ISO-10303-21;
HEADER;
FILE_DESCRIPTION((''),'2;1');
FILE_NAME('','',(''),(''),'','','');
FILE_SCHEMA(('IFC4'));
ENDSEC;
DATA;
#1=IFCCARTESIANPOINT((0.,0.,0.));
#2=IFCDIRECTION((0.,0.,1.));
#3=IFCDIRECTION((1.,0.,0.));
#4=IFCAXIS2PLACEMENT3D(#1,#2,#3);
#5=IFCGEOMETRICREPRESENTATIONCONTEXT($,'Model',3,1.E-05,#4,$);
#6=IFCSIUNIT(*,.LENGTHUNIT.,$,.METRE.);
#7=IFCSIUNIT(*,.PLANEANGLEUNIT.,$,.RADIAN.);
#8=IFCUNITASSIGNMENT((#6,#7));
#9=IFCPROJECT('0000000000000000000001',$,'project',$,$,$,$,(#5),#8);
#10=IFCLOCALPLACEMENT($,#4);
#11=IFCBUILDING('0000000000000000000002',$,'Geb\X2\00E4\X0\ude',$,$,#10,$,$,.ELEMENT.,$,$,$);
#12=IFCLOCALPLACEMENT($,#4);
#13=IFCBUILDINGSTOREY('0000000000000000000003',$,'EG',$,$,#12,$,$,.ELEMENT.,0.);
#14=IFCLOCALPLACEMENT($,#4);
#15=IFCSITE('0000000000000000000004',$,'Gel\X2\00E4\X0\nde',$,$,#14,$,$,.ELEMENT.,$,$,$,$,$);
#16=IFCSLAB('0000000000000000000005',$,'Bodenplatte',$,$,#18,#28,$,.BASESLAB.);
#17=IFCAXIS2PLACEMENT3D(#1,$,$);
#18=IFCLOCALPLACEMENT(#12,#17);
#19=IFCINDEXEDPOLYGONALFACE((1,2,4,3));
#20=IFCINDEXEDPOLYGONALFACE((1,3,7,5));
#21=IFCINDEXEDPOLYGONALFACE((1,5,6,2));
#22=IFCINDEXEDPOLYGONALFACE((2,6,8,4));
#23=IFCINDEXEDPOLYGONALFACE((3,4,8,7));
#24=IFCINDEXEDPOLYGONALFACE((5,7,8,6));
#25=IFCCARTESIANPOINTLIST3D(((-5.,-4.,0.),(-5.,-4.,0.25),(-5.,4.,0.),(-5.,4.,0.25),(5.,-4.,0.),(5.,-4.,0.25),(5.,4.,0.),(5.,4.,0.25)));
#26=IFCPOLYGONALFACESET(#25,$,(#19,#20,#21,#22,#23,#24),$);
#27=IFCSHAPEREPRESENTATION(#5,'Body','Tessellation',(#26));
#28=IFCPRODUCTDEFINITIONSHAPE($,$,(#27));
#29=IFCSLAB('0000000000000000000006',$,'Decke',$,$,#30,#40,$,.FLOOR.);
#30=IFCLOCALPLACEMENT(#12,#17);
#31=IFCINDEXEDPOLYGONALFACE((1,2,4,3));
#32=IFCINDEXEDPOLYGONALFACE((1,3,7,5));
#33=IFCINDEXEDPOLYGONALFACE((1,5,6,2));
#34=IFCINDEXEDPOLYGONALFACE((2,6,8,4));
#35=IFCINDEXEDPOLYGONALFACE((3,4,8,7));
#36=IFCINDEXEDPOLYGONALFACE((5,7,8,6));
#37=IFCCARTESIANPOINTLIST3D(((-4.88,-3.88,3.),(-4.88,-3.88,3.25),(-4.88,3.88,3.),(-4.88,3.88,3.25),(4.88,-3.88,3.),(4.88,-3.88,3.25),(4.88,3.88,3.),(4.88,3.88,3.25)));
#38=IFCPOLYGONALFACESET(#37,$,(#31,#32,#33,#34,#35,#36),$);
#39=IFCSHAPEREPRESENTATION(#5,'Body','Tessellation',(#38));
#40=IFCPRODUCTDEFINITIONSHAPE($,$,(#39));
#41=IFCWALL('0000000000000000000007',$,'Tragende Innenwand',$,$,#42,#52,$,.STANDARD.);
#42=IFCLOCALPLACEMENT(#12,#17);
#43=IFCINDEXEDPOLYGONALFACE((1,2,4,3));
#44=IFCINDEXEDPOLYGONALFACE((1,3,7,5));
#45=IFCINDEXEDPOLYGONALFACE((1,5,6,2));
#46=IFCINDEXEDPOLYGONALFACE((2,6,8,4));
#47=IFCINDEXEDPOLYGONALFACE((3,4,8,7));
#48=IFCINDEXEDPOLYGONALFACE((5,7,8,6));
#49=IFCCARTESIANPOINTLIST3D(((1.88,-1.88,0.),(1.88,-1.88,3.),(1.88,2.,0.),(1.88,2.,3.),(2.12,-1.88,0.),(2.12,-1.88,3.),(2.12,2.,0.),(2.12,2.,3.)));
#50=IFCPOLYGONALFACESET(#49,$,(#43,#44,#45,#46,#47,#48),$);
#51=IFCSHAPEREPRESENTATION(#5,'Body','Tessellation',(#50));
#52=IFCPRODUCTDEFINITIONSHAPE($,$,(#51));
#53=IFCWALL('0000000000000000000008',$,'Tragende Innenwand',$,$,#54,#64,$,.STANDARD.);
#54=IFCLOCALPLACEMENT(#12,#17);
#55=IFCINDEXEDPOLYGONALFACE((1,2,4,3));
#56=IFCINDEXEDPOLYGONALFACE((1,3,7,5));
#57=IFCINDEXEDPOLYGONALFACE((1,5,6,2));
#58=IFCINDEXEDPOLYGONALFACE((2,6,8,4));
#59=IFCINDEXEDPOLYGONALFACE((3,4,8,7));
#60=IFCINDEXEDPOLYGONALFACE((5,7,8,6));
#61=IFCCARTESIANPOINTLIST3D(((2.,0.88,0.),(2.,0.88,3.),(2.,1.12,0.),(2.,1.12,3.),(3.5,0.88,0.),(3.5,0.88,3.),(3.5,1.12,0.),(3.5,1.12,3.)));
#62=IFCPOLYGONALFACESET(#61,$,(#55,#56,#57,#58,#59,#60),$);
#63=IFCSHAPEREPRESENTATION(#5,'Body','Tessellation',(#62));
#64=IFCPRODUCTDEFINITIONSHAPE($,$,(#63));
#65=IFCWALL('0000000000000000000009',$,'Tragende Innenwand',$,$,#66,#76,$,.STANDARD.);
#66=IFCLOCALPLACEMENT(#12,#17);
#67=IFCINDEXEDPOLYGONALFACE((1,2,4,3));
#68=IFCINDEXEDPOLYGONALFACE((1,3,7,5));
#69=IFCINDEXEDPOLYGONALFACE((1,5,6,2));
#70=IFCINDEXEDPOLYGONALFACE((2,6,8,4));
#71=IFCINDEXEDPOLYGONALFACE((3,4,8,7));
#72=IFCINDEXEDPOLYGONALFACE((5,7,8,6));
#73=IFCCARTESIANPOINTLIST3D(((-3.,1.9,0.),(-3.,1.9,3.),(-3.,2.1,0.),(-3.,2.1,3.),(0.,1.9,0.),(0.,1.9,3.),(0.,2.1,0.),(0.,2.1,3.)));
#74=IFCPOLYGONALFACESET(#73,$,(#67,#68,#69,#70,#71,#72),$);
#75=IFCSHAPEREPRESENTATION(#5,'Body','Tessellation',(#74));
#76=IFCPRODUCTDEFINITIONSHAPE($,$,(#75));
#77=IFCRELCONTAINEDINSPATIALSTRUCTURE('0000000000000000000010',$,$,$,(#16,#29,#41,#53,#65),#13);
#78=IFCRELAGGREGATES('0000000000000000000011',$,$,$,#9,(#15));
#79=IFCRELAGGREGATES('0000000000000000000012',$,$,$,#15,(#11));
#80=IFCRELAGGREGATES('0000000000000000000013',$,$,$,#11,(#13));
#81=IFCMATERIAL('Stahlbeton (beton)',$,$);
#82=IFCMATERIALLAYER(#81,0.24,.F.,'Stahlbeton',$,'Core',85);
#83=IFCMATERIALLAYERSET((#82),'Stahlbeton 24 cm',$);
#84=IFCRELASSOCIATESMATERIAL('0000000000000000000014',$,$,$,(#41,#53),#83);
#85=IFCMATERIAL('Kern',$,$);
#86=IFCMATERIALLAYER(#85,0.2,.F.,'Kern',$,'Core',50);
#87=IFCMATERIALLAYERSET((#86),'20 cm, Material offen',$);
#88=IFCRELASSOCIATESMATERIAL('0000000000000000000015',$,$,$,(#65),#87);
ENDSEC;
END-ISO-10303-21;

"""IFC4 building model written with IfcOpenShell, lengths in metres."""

from ifc_helpers import new_model, si_unit, frame, origin_with_axes, origin_2d, place, context, project, spatial, polyline, rectangle, outline, extrude, material, layer, layer_set, layer_usage, element, save


model = new_model("IFC4")

# Units and contexts
model_context = context("Model", 3, precision=1e-05, world=origin_with_axes())
ifc_project = project(units=[si_unit("LENGTHUNIT", "METRE"), si_unit("PLANEANGLEUNIT", "RADIAN")], contexts=[model_context])

# Site, building, storey
site_placement = place(None, origin_with_axes())
site = spatial("IfcSite", under=ifc_project, at=site_placement, Name="Gelände", CompositionType="ELEMENT")
building_placement = place(None, origin_with_axes())
building = spatial("IfcBuilding", under=site, at=building_placement, Name="Gebäude", CompositionType="ELEMENT")
storey_placement = place(None, origin_with_axes())
storey = spatial("IfcBuildingStorey", under=building, at=storey_placement, Name="EG", CompositionType="ELEMENT", Elevation=0.0)

# Slabs
slab_1_placement = place(None, origin_with_axes())
element("IfcSlab", 1, at=slab_1_placement, inside=storey, Name="Bodenplatte", PredefinedType="BASESLAB", context=model_context, shape_type="SweptSolid", body=[
    extrude(outline(polyline([(-5.0, -4.0), (5.0, -4.0), (5.0, 4.0), (-5.0, 4.0), (-5.0, -4.0)])), origin_with_axes(), (0.0, 0.0, 1.0), 0.25),
])
slab_2_placement = place(None, frame((0.0, 0.0, 3.0), z_axis=(0.0, 0.0, 1.0), x_axis=(1.0, 0.0, 0.0)))
element("IfcSlab", 2, at=slab_2_placement, inside=storey, Name="Decke", PredefinedType="FLOOR", context=model_context, shape_type="SweptSolid", body=[
    extrude(outline(polyline([(-4.88, -3.88), (4.88, -3.88), (4.88, 3.88), (-4.88, 3.88), (-4.88, -3.88)])), origin_with_axes(), (0.0, 0.0, 1.0), 0.25),
])

# Shared definitions
ifc_material_1 = material(Name="Stahlbeton (beton)")
ifc_layer_1 = layer(ifc_material_1, 0.24, ventilated=False, Name="Stahlbeton", Category="Core", Priority=85)
ifc_layer_set_1 = layer_set([ifc_layer_1], Name="Stahlbeton 24 cm")

# Walls
ifc_layer_usage_1 = layer_usage(ifc_layer_set_1, "AXIS2", "NEGATIVE", 0.12)
wall_1_placement = place(None, frame((2.0, 0.0, 0.0), z_axis=(0.0, 0.0, 1.0), x_axis=(0.0, 1.0, 0.0)))
element("IfcWall", 3, at=wall_1_placement, inside=storey, material=ifc_layer_usage_1, Name="Tragende Innenwand", PredefinedType="STANDARD", context=model_context, shape_type="SweptSolid", body=[
    extrude(outline(polyline([(-1.88, -0.12), (2.0, -0.12), (2.0, 0.12), (-1.88, 0.12), (-1.88, -0.12)])), origin_with_axes(), (0.0, 0.0, 1.0), 3.0),
])
ifc_layer_usage_2 = layer_usage(ifc_layer_set_1, "AXIS2", "NEGATIVE", 0.12)
wall_2_placement = place(None, frame((2.75, 1.0, 0.0), z_axis=(0.0, 0.0, 1.0), x_axis=(1.0, 0.0, 0.0)))
element("IfcWall", 4, at=wall_2_placement, inside=storey, material=ifc_layer_usage_2, Name="Tragende Innenwand", PredefinedType="STANDARD", context=model_context, shape_type="SweptSolid", body=[
    extrude(outline(polyline([(-0.75, -0.12), (0.75, -0.12), (0.75, 0.12), (-0.75, 0.12), (-0.75, -0.12)])), origin_with_axes(), (0.0, 0.0, 1.0), 3.0),
])
ifc_material_2 = material(Name="Kern")
ifc_layer_2 = layer(ifc_material_2, 0.2, ventilated=False, Name="Kern", Category="Core", Priority=50)
ifc_layer_set_2 = layer_set([ifc_layer_2], Name="20 cm, Material offen")
wall_3_placement = place(None, frame((-1.5, 2.0, 0.0), z_axis=(0.0, 0.0, 1.0), x_axis=(1.0, 0.0, 0.0)))
element("IfcWall", 5, at=wall_3_placement, inside=storey, material=ifc_layer_set_2, Name="Tragende Innenwand", PredefinedType="STANDARD", context=model_context, shape_type="SweptSolid", body=[
    extrude(rectangle(XDim=3.0, YDim=0.2, at=origin_2d()), origin_with_axes(), (0.0, 0.0, 1.0), 3.0),
])

save(model, "model.ifc")
